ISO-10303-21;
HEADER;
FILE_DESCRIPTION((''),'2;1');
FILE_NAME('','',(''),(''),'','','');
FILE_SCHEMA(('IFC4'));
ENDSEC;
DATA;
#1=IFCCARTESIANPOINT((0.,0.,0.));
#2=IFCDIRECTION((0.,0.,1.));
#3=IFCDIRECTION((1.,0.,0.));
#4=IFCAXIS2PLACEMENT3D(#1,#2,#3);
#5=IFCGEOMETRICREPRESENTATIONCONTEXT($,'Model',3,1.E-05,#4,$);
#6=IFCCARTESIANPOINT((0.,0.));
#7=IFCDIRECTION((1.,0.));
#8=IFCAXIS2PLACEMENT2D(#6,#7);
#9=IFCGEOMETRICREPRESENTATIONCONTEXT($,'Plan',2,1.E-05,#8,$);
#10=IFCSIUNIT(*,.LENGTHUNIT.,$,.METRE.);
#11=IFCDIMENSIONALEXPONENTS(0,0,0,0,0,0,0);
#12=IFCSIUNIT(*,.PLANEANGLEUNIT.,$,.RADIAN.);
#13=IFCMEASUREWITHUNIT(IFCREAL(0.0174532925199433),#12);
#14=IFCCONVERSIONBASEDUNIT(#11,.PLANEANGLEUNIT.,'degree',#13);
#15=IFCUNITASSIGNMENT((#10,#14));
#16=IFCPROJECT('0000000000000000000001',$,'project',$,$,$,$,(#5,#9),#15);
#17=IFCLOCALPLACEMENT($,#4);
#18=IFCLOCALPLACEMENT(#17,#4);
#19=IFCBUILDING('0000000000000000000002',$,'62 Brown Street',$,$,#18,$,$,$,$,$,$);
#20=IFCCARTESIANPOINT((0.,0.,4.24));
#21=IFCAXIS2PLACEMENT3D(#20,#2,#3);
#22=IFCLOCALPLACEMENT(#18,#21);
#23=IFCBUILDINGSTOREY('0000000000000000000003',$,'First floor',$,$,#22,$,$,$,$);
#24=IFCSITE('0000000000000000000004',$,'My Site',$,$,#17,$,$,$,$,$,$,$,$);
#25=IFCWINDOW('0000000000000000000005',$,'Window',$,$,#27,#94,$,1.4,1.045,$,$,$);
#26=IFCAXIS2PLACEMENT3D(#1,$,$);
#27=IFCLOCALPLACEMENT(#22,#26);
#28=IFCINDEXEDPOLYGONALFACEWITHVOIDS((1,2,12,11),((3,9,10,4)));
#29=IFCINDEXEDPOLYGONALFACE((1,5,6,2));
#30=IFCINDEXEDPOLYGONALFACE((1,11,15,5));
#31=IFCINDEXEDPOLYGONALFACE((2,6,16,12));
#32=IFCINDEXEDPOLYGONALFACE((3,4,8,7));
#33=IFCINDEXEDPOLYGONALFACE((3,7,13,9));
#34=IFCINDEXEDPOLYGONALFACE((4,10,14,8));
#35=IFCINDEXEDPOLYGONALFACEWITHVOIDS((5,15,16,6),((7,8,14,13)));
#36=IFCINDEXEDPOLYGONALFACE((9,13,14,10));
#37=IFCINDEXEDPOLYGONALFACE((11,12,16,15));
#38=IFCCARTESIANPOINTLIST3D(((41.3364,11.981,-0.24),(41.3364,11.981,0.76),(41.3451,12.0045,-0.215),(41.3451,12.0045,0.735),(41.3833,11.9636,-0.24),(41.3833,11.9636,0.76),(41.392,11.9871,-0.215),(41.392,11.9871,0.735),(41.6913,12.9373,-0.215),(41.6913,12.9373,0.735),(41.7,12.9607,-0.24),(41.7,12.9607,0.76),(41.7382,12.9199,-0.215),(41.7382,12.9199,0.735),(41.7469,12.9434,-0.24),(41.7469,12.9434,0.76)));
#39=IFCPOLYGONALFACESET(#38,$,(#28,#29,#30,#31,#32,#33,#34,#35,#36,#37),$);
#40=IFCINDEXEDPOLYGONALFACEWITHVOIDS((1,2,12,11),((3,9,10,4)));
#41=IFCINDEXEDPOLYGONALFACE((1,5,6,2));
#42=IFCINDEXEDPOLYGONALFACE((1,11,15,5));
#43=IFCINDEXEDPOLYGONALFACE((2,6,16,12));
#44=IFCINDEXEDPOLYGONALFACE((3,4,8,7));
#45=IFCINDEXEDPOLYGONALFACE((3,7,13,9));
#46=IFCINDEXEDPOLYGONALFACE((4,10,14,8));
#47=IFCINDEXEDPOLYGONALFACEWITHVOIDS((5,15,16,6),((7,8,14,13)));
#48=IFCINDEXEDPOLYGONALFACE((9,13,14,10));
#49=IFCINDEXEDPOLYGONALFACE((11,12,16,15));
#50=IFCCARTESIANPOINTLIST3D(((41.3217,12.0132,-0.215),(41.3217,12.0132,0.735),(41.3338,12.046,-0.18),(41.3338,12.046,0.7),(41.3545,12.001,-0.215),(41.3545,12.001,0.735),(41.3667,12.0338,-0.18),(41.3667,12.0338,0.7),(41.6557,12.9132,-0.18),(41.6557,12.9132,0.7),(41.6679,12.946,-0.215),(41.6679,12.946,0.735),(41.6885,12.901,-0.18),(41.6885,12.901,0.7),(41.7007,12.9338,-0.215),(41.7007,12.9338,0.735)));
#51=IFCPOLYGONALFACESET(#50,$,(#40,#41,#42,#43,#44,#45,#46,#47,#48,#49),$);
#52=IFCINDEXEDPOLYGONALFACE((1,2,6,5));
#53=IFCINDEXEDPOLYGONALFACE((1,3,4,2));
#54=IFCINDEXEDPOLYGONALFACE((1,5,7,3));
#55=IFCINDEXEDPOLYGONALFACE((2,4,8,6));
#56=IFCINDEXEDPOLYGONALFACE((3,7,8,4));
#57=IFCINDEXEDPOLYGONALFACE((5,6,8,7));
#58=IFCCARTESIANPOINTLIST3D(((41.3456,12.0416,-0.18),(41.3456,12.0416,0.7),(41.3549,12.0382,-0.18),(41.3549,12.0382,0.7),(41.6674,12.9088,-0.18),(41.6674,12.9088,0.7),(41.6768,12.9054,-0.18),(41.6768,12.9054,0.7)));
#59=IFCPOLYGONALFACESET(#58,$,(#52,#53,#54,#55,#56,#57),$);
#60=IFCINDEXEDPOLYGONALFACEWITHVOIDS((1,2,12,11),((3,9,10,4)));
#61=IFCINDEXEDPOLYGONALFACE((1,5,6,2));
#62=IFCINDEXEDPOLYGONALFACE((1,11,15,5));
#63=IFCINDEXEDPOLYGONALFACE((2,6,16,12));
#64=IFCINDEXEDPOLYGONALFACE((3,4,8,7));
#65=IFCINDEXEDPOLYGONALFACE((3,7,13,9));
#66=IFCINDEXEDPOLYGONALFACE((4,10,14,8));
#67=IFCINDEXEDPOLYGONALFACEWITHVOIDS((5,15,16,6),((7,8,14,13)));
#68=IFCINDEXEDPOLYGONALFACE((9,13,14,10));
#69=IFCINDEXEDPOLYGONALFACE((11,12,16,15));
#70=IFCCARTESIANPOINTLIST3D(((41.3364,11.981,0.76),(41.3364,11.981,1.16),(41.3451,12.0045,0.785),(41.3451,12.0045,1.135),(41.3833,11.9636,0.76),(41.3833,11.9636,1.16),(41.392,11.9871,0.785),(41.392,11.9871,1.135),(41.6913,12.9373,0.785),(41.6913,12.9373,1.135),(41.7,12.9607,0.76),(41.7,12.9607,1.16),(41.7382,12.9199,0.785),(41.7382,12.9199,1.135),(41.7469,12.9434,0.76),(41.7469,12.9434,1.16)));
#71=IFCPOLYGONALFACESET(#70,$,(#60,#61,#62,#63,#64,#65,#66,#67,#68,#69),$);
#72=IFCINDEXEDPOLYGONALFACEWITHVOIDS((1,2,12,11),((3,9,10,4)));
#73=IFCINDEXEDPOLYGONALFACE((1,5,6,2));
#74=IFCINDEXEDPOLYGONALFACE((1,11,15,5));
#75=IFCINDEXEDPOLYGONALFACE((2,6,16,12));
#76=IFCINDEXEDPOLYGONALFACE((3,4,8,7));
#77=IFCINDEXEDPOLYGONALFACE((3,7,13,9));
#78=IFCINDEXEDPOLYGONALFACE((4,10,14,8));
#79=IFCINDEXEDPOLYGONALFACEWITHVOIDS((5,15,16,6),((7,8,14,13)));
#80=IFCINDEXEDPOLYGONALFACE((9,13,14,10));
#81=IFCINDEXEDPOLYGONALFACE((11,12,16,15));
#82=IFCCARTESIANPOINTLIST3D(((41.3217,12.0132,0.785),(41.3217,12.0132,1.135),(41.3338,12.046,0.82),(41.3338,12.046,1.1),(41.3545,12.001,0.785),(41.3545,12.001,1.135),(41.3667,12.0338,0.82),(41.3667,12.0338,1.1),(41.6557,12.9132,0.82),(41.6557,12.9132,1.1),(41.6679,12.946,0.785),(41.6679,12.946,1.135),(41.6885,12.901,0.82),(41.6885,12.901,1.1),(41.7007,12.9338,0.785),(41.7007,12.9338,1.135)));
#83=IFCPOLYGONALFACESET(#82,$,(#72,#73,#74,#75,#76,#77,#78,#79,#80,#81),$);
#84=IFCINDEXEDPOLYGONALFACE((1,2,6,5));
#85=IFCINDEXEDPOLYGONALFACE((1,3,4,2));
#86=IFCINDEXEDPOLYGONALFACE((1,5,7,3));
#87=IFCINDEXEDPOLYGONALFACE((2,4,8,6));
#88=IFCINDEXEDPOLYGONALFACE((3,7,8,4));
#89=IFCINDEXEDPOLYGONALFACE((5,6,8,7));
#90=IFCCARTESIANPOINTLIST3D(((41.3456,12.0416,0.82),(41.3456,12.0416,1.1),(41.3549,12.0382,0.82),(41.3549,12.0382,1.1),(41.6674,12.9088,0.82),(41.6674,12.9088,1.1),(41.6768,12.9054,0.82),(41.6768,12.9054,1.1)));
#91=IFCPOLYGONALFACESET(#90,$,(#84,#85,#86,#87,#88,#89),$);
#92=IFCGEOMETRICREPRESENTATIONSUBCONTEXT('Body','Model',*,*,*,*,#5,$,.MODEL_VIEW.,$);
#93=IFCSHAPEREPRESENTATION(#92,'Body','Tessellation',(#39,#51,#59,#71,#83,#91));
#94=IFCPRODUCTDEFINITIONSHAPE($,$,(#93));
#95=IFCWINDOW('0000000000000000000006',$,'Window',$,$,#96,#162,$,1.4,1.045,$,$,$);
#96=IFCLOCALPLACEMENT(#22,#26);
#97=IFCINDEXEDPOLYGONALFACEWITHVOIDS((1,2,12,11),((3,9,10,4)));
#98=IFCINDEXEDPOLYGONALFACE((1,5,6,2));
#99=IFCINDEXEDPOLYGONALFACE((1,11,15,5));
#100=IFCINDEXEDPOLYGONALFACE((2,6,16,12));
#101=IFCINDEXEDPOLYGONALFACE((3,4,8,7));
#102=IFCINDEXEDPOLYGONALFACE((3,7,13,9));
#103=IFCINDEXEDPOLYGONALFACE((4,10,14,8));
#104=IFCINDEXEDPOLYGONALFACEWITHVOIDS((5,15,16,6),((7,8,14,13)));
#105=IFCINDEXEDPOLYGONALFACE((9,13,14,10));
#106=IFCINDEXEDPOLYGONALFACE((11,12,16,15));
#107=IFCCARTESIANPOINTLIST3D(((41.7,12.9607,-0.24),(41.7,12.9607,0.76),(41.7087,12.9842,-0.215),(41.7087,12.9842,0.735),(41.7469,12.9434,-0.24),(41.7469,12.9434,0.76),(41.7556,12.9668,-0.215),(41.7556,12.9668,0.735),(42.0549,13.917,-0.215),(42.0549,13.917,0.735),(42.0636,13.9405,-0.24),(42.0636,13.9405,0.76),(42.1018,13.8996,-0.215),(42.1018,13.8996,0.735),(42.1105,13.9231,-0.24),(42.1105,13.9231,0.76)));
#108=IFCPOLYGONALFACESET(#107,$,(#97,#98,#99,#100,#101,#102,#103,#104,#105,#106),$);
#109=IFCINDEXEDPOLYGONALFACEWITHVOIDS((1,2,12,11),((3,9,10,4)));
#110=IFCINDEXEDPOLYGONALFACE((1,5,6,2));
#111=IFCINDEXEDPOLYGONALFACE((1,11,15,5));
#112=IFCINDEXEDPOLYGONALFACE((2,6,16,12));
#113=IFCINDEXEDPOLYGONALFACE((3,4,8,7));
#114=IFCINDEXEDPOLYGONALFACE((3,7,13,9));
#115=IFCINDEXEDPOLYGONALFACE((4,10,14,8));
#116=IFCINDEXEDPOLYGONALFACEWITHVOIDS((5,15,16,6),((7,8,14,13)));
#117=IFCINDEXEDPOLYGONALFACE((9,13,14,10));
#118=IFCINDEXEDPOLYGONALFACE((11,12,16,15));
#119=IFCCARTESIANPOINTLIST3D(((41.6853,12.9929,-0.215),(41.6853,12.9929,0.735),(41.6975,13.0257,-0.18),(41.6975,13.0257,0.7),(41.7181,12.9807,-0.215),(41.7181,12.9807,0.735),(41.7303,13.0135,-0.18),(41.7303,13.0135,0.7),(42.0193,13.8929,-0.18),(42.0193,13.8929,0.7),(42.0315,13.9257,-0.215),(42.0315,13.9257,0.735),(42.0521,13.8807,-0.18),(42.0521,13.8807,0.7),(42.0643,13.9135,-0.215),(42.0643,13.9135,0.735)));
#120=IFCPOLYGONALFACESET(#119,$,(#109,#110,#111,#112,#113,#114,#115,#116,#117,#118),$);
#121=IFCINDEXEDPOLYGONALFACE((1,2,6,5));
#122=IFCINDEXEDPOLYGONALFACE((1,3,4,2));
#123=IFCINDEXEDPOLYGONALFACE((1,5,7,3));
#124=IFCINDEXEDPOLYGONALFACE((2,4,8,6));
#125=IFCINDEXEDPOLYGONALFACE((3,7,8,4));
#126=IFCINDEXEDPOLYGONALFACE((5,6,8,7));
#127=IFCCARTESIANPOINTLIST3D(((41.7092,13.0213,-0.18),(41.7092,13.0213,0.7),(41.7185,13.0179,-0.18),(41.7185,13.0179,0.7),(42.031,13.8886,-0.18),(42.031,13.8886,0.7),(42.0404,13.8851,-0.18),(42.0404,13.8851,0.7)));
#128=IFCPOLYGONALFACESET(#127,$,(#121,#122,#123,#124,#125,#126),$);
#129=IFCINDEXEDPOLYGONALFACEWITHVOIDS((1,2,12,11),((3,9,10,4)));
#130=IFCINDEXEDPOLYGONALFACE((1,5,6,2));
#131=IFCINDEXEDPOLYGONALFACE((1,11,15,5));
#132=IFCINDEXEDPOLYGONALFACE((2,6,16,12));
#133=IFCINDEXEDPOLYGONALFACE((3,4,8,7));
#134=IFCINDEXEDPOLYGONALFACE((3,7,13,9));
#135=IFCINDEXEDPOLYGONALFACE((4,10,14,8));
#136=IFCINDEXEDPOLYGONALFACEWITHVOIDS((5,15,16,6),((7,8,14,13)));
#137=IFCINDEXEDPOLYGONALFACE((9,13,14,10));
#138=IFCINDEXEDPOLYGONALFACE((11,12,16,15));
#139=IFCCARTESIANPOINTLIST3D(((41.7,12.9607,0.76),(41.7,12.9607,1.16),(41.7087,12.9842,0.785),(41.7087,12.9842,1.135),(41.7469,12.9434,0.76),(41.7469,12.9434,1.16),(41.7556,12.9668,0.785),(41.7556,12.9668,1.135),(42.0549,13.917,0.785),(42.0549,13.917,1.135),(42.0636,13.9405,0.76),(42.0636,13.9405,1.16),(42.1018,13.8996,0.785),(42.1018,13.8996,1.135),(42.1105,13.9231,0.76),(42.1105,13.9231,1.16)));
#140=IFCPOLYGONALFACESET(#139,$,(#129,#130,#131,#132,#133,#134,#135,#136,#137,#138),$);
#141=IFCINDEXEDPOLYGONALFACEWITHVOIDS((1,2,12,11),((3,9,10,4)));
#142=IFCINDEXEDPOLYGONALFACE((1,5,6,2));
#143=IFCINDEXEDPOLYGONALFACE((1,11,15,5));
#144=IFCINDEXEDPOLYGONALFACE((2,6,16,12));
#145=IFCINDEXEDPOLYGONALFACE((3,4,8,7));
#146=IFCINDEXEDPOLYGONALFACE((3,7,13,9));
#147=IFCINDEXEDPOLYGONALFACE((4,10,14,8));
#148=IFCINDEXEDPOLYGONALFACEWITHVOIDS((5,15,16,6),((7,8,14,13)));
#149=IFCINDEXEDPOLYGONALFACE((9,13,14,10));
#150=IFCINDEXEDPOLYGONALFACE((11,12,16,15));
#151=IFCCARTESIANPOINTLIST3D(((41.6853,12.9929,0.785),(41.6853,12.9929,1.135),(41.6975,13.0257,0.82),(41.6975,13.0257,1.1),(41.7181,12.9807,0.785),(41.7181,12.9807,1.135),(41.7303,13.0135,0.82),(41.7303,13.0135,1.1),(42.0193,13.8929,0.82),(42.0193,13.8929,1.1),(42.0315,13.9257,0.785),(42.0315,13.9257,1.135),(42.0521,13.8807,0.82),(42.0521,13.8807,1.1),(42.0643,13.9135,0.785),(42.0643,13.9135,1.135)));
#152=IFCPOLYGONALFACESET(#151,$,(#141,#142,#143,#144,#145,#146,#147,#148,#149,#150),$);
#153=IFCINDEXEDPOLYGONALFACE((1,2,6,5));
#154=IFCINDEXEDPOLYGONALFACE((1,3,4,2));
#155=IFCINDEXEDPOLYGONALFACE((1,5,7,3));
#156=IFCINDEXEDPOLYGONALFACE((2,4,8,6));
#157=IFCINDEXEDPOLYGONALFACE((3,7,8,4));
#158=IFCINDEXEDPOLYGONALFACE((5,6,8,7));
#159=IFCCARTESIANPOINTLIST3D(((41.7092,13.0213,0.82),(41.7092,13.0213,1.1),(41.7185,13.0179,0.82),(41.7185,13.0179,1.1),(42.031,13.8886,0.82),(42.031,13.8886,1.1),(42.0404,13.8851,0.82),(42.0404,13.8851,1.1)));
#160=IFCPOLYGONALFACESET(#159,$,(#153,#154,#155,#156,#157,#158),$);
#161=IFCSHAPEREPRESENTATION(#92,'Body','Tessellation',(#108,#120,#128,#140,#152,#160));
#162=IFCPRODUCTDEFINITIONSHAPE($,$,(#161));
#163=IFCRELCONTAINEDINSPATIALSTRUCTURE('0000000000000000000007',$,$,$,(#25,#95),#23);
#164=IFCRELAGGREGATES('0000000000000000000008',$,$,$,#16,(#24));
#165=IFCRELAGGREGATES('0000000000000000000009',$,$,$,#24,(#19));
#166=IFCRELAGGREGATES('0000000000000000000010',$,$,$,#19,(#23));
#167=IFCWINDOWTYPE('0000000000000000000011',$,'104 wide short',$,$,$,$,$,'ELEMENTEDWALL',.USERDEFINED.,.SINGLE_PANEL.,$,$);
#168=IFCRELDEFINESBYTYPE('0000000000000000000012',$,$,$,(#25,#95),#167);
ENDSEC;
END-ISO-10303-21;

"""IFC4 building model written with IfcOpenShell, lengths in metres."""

from ifc_helpers import new_model, entity, si_unit, converted_unit, frame, origin_with_axes, origin_2d_with_axis, place, context, subcontext, project, spatial, line, indexed_curve, outline, extrude, shape, source, transform, mapped, type_object, type_shapes, element, save


model = new_model("IFC4")

# Units and contexts
model_context = context("Model", 3, precision=1e-05, world=origin_with_axes())
plan_context = context("Plan", 2, precision=1e-05, world=origin_2d_with_axis())
body_context_1 = subcontext(model_context, "Body", "Model", "MODEL_VIEW")
body_context_2 = subcontext(plan_context, "Body", "Plan", "PLAN_VIEW")
ifc_project = project(units=[si_unit("LENGTHUNIT", "METRE"), converted_unit("PLANEANGLEUNIT", "degree", entity("IfcReal", 0.0174532925199433), si_unit("PLANEANGLEUNIT", "RADIAN"), dimensions=[0, 0, 0, 0, 0, 0, 0])], contexts=[model_context, plan_context])

# Site, building, storey
site_placement = place(None, origin_with_axes())
site = spatial("IfcSite", under=ifc_project, at=site_placement, Name="My Site")
building_placement = place(site_placement, origin_with_axes())
building = spatial("IfcBuilding", under=site, at=building_placement, Name="62 Brown Street")
storey_placement = place(building_placement, frame((0.0, 0.0, 4.24), z_axis=(0.0, 0.0, 1.0), x_axis=(1.0, 0.0, 0.0)))
storey = spatial("IfcBuildingStorey", under=building, at=storey_placement, Name="First floor")

# Shared definitions
window_type = type_object("IfcWindowType", Name="104 wide short", ElementType="ELEMENTEDWALL", PartitioningType="SINGLE_PANEL", PredefinedType="USERDEFINED")
shared_shape_1 = source(origin_with_axes(), body_context_1, "Body", "SweptSolid", [
    extrude(outline(indexed_curve([(0.0, 0.0), (1.045, 0.0), (1.045, 1.0), (0.0, 1.0)], segments=[line(1, 2, 3, 4, 1)]), holes=[indexed_curve([(0.025, 0.025), (1.02, 0.025), (1.02, 0.975), (0.025, 0.975)], segments=[line(1, 2, 3, 4, 1)])]), frame((0.0, 0.15, 0.0), z_axis=(0.0, -1.0, 0.0), x_axis=(1.0, 0.0, 0.0)), (0.0, 0.0, -1.0), 0.05),
    extrude(outline(indexed_curve([(0.0, 0.0), (0.995, 0.0), (0.995, 0.95), (0.0, 0.95)], segments=[line(1, 2, 3, 4, 1)]), holes=[indexed_curve([(0.035, 0.035), (0.96, 0.035), (0.96, 0.915), (0.035, 0.915)], segments=[line(1, 2, 3, 4, 1)])]), frame((0.025, 0.19, 0.025), z_axis=(0.0, -1.0, 0.0), x_axis=(1.0, 0.0, 0.0)), (0.0, 0.0, -1.0), 0.035),
    extrude(outline(indexed_curve([(0.035, 0.035), (0.96, 0.035), (0.96, 0.915), (0.035, 0.915)], segments=[line(1, 2, 3, 4, 1)])), frame((0.025, 0.2025, 0.025), z_axis=(0.0, -1.0, 0.0), x_axis=(1.0, 0.0, 0.0)), (0.0, 0.0, -1.0), 0.01),
    extrude(outline(indexed_curve([(0.0, 0.0), (1.045, 0.0), (1.045, 0.4), (0.0, 0.4)], segments=[line(1, 2, 3, 4, 1)]), holes=[indexed_curve([(0.025, 0.025), (1.02, 0.025), (1.02, 0.375), (0.025, 0.375)], segments=[line(1, 2, 3, 4, 1)])]), frame((0.0, 0.15, 1.0), z_axis=(0.0, -1.0, 0.0), x_axis=(1.0, 0.0, 0.0)), (0.0, 0.0, -1.0), 0.05),
    extrude(outline(indexed_curve([(0.0, 0.0), (0.995, 0.0), (0.995, 0.35), (0.0, 0.35)], segments=[line(1, 2, 3, 4, 1)]), holes=[indexed_curve([(0.035, 0.035), (0.96, 0.035), (0.96, 0.315), (0.035, 0.315)], segments=[line(1, 2, 3, 4, 1)])]), frame((0.025, 0.19, 1.025), z_axis=(0.0, -1.0, 0.0), x_axis=(1.0, 0.0, 0.0)), (0.0, 0.0, -1.0), 0.035),
    extrude(outline(indexed_curve([(0.035, 0.035), (0.96, 0.035), (0.96, 0.315), (0.035, 0.315)], segments=[line(1, 2, 3, 4, 1)])), frame((0.025, 0.2025, 1.025), z_axis=(0.0, -1.0, 0.0), x_axis=(1.0, 0.0, 0.0)), (0.0, 0.0, -1.0), 0.01),
])
shared_shape_2 = source(origin_with_axes(), body_context_2, "Body", "Curve2D", [
    entity("IfcIndexedPolyCurve", entity("IfcCartesianPointList2D", [[0.025, 0.15], [1.02, 0.15]])),
    entity("IfcIndexedPolyCurve", entity("IfcCartesianPointList2D", [[0.0, 0.2], [0.025, 0.2], [0.025, 0.15], [0.0, 0.15]]), [entity("IfcLineIndex", [1, 2, 3, 4, 1])]),
    entity("IfcIndexedPolyCurve", entity("IfcCartesianPointList2D", [[1.045, 0.2], [1.02, 0.2], [1.02, 0.15], [1.045, 0.15]]), [entity("IfcLineIndex", [1, 2, 3, 4, 1])]),
    entity("IfcIndexedPolyCurve", entity("IfcCartesianPointList2D", [[0.025, 0.19], [0.06, 0.19], [0.06, 0.225], [0.025, 0.225]]), [entity("IfcLineIndex", [1, 2, 3, 4, 1])]),
    entity("IfcIndexedPolyCurve", entity("IfcCartesianPointList2D", [[1.02, 0.19], [0.985, 0.19], [0.985, 0.225], [1.02, 0.225]]), [entity("IfcLineIndex", [1, 2, 3, 4, 1])]),
    entity("IfcIndexedPolyCurve", entity("IfcCartesianPointList2D", [[0.06, 0.19], [0.985, 0.19]])),
    entity("IfcIndexedPolyCurve", entity("IfcCartesianPointList2D", [[0.06, 0.225], [0.985, 0.225]])),
    entity("IfcIndexedPolyCurve", entity("IfcCartesianPointList2D", [[0.06, 0.2075], [0.985, 0.2075]])),
])
type_shapes(window_type, [shared_shape_1, shared_shape_2])

# Windows
for number, where, z_axis, x_axis, name in (
    (1, (41.5239, 11.9115, -0.24), (0.0, 0.0, 1.0), (0.347944, 0.937515, 0.0), "Window"),
    (2, (41.8875, 12.8912, -0.24), (0.0, 0.0, 1.0), (0.347944, 0.937515, 0.0), "Window"),
):
    element("IfcWindow", number, at=place(storey_placement, frame(where, z_axis=z_axis, x_axis=x_axis)), inside=storey, type_object=window_type, Name=name, OverallHeight=1.4, OverallWidth=1.045, shapes=[
        shape(body_context_1, "Body", "MappedRepresentation", [mapped(shared_shape_1, transform((0.0, 0.0, 0.0), x_axis=(1.0, 0.0, 0.0), y_axis=(0.0, 1.0, 0.0), z_axis=(0.0, 0.0, 1.0), scale=1.0))]),
        shape(body_context_2, "Body", "MappedRepresentation", [mapped(shared_shape_2, transform((0.0, 0.0, 0.0), x_axis=(1.0, 0.0, 0.0), y_axis=(0.0, 1.0, 0.0), z_axis=(0.0, 0.0, 1.0), scale=1.0))]),
    ])

save(model, "model.ifc")
